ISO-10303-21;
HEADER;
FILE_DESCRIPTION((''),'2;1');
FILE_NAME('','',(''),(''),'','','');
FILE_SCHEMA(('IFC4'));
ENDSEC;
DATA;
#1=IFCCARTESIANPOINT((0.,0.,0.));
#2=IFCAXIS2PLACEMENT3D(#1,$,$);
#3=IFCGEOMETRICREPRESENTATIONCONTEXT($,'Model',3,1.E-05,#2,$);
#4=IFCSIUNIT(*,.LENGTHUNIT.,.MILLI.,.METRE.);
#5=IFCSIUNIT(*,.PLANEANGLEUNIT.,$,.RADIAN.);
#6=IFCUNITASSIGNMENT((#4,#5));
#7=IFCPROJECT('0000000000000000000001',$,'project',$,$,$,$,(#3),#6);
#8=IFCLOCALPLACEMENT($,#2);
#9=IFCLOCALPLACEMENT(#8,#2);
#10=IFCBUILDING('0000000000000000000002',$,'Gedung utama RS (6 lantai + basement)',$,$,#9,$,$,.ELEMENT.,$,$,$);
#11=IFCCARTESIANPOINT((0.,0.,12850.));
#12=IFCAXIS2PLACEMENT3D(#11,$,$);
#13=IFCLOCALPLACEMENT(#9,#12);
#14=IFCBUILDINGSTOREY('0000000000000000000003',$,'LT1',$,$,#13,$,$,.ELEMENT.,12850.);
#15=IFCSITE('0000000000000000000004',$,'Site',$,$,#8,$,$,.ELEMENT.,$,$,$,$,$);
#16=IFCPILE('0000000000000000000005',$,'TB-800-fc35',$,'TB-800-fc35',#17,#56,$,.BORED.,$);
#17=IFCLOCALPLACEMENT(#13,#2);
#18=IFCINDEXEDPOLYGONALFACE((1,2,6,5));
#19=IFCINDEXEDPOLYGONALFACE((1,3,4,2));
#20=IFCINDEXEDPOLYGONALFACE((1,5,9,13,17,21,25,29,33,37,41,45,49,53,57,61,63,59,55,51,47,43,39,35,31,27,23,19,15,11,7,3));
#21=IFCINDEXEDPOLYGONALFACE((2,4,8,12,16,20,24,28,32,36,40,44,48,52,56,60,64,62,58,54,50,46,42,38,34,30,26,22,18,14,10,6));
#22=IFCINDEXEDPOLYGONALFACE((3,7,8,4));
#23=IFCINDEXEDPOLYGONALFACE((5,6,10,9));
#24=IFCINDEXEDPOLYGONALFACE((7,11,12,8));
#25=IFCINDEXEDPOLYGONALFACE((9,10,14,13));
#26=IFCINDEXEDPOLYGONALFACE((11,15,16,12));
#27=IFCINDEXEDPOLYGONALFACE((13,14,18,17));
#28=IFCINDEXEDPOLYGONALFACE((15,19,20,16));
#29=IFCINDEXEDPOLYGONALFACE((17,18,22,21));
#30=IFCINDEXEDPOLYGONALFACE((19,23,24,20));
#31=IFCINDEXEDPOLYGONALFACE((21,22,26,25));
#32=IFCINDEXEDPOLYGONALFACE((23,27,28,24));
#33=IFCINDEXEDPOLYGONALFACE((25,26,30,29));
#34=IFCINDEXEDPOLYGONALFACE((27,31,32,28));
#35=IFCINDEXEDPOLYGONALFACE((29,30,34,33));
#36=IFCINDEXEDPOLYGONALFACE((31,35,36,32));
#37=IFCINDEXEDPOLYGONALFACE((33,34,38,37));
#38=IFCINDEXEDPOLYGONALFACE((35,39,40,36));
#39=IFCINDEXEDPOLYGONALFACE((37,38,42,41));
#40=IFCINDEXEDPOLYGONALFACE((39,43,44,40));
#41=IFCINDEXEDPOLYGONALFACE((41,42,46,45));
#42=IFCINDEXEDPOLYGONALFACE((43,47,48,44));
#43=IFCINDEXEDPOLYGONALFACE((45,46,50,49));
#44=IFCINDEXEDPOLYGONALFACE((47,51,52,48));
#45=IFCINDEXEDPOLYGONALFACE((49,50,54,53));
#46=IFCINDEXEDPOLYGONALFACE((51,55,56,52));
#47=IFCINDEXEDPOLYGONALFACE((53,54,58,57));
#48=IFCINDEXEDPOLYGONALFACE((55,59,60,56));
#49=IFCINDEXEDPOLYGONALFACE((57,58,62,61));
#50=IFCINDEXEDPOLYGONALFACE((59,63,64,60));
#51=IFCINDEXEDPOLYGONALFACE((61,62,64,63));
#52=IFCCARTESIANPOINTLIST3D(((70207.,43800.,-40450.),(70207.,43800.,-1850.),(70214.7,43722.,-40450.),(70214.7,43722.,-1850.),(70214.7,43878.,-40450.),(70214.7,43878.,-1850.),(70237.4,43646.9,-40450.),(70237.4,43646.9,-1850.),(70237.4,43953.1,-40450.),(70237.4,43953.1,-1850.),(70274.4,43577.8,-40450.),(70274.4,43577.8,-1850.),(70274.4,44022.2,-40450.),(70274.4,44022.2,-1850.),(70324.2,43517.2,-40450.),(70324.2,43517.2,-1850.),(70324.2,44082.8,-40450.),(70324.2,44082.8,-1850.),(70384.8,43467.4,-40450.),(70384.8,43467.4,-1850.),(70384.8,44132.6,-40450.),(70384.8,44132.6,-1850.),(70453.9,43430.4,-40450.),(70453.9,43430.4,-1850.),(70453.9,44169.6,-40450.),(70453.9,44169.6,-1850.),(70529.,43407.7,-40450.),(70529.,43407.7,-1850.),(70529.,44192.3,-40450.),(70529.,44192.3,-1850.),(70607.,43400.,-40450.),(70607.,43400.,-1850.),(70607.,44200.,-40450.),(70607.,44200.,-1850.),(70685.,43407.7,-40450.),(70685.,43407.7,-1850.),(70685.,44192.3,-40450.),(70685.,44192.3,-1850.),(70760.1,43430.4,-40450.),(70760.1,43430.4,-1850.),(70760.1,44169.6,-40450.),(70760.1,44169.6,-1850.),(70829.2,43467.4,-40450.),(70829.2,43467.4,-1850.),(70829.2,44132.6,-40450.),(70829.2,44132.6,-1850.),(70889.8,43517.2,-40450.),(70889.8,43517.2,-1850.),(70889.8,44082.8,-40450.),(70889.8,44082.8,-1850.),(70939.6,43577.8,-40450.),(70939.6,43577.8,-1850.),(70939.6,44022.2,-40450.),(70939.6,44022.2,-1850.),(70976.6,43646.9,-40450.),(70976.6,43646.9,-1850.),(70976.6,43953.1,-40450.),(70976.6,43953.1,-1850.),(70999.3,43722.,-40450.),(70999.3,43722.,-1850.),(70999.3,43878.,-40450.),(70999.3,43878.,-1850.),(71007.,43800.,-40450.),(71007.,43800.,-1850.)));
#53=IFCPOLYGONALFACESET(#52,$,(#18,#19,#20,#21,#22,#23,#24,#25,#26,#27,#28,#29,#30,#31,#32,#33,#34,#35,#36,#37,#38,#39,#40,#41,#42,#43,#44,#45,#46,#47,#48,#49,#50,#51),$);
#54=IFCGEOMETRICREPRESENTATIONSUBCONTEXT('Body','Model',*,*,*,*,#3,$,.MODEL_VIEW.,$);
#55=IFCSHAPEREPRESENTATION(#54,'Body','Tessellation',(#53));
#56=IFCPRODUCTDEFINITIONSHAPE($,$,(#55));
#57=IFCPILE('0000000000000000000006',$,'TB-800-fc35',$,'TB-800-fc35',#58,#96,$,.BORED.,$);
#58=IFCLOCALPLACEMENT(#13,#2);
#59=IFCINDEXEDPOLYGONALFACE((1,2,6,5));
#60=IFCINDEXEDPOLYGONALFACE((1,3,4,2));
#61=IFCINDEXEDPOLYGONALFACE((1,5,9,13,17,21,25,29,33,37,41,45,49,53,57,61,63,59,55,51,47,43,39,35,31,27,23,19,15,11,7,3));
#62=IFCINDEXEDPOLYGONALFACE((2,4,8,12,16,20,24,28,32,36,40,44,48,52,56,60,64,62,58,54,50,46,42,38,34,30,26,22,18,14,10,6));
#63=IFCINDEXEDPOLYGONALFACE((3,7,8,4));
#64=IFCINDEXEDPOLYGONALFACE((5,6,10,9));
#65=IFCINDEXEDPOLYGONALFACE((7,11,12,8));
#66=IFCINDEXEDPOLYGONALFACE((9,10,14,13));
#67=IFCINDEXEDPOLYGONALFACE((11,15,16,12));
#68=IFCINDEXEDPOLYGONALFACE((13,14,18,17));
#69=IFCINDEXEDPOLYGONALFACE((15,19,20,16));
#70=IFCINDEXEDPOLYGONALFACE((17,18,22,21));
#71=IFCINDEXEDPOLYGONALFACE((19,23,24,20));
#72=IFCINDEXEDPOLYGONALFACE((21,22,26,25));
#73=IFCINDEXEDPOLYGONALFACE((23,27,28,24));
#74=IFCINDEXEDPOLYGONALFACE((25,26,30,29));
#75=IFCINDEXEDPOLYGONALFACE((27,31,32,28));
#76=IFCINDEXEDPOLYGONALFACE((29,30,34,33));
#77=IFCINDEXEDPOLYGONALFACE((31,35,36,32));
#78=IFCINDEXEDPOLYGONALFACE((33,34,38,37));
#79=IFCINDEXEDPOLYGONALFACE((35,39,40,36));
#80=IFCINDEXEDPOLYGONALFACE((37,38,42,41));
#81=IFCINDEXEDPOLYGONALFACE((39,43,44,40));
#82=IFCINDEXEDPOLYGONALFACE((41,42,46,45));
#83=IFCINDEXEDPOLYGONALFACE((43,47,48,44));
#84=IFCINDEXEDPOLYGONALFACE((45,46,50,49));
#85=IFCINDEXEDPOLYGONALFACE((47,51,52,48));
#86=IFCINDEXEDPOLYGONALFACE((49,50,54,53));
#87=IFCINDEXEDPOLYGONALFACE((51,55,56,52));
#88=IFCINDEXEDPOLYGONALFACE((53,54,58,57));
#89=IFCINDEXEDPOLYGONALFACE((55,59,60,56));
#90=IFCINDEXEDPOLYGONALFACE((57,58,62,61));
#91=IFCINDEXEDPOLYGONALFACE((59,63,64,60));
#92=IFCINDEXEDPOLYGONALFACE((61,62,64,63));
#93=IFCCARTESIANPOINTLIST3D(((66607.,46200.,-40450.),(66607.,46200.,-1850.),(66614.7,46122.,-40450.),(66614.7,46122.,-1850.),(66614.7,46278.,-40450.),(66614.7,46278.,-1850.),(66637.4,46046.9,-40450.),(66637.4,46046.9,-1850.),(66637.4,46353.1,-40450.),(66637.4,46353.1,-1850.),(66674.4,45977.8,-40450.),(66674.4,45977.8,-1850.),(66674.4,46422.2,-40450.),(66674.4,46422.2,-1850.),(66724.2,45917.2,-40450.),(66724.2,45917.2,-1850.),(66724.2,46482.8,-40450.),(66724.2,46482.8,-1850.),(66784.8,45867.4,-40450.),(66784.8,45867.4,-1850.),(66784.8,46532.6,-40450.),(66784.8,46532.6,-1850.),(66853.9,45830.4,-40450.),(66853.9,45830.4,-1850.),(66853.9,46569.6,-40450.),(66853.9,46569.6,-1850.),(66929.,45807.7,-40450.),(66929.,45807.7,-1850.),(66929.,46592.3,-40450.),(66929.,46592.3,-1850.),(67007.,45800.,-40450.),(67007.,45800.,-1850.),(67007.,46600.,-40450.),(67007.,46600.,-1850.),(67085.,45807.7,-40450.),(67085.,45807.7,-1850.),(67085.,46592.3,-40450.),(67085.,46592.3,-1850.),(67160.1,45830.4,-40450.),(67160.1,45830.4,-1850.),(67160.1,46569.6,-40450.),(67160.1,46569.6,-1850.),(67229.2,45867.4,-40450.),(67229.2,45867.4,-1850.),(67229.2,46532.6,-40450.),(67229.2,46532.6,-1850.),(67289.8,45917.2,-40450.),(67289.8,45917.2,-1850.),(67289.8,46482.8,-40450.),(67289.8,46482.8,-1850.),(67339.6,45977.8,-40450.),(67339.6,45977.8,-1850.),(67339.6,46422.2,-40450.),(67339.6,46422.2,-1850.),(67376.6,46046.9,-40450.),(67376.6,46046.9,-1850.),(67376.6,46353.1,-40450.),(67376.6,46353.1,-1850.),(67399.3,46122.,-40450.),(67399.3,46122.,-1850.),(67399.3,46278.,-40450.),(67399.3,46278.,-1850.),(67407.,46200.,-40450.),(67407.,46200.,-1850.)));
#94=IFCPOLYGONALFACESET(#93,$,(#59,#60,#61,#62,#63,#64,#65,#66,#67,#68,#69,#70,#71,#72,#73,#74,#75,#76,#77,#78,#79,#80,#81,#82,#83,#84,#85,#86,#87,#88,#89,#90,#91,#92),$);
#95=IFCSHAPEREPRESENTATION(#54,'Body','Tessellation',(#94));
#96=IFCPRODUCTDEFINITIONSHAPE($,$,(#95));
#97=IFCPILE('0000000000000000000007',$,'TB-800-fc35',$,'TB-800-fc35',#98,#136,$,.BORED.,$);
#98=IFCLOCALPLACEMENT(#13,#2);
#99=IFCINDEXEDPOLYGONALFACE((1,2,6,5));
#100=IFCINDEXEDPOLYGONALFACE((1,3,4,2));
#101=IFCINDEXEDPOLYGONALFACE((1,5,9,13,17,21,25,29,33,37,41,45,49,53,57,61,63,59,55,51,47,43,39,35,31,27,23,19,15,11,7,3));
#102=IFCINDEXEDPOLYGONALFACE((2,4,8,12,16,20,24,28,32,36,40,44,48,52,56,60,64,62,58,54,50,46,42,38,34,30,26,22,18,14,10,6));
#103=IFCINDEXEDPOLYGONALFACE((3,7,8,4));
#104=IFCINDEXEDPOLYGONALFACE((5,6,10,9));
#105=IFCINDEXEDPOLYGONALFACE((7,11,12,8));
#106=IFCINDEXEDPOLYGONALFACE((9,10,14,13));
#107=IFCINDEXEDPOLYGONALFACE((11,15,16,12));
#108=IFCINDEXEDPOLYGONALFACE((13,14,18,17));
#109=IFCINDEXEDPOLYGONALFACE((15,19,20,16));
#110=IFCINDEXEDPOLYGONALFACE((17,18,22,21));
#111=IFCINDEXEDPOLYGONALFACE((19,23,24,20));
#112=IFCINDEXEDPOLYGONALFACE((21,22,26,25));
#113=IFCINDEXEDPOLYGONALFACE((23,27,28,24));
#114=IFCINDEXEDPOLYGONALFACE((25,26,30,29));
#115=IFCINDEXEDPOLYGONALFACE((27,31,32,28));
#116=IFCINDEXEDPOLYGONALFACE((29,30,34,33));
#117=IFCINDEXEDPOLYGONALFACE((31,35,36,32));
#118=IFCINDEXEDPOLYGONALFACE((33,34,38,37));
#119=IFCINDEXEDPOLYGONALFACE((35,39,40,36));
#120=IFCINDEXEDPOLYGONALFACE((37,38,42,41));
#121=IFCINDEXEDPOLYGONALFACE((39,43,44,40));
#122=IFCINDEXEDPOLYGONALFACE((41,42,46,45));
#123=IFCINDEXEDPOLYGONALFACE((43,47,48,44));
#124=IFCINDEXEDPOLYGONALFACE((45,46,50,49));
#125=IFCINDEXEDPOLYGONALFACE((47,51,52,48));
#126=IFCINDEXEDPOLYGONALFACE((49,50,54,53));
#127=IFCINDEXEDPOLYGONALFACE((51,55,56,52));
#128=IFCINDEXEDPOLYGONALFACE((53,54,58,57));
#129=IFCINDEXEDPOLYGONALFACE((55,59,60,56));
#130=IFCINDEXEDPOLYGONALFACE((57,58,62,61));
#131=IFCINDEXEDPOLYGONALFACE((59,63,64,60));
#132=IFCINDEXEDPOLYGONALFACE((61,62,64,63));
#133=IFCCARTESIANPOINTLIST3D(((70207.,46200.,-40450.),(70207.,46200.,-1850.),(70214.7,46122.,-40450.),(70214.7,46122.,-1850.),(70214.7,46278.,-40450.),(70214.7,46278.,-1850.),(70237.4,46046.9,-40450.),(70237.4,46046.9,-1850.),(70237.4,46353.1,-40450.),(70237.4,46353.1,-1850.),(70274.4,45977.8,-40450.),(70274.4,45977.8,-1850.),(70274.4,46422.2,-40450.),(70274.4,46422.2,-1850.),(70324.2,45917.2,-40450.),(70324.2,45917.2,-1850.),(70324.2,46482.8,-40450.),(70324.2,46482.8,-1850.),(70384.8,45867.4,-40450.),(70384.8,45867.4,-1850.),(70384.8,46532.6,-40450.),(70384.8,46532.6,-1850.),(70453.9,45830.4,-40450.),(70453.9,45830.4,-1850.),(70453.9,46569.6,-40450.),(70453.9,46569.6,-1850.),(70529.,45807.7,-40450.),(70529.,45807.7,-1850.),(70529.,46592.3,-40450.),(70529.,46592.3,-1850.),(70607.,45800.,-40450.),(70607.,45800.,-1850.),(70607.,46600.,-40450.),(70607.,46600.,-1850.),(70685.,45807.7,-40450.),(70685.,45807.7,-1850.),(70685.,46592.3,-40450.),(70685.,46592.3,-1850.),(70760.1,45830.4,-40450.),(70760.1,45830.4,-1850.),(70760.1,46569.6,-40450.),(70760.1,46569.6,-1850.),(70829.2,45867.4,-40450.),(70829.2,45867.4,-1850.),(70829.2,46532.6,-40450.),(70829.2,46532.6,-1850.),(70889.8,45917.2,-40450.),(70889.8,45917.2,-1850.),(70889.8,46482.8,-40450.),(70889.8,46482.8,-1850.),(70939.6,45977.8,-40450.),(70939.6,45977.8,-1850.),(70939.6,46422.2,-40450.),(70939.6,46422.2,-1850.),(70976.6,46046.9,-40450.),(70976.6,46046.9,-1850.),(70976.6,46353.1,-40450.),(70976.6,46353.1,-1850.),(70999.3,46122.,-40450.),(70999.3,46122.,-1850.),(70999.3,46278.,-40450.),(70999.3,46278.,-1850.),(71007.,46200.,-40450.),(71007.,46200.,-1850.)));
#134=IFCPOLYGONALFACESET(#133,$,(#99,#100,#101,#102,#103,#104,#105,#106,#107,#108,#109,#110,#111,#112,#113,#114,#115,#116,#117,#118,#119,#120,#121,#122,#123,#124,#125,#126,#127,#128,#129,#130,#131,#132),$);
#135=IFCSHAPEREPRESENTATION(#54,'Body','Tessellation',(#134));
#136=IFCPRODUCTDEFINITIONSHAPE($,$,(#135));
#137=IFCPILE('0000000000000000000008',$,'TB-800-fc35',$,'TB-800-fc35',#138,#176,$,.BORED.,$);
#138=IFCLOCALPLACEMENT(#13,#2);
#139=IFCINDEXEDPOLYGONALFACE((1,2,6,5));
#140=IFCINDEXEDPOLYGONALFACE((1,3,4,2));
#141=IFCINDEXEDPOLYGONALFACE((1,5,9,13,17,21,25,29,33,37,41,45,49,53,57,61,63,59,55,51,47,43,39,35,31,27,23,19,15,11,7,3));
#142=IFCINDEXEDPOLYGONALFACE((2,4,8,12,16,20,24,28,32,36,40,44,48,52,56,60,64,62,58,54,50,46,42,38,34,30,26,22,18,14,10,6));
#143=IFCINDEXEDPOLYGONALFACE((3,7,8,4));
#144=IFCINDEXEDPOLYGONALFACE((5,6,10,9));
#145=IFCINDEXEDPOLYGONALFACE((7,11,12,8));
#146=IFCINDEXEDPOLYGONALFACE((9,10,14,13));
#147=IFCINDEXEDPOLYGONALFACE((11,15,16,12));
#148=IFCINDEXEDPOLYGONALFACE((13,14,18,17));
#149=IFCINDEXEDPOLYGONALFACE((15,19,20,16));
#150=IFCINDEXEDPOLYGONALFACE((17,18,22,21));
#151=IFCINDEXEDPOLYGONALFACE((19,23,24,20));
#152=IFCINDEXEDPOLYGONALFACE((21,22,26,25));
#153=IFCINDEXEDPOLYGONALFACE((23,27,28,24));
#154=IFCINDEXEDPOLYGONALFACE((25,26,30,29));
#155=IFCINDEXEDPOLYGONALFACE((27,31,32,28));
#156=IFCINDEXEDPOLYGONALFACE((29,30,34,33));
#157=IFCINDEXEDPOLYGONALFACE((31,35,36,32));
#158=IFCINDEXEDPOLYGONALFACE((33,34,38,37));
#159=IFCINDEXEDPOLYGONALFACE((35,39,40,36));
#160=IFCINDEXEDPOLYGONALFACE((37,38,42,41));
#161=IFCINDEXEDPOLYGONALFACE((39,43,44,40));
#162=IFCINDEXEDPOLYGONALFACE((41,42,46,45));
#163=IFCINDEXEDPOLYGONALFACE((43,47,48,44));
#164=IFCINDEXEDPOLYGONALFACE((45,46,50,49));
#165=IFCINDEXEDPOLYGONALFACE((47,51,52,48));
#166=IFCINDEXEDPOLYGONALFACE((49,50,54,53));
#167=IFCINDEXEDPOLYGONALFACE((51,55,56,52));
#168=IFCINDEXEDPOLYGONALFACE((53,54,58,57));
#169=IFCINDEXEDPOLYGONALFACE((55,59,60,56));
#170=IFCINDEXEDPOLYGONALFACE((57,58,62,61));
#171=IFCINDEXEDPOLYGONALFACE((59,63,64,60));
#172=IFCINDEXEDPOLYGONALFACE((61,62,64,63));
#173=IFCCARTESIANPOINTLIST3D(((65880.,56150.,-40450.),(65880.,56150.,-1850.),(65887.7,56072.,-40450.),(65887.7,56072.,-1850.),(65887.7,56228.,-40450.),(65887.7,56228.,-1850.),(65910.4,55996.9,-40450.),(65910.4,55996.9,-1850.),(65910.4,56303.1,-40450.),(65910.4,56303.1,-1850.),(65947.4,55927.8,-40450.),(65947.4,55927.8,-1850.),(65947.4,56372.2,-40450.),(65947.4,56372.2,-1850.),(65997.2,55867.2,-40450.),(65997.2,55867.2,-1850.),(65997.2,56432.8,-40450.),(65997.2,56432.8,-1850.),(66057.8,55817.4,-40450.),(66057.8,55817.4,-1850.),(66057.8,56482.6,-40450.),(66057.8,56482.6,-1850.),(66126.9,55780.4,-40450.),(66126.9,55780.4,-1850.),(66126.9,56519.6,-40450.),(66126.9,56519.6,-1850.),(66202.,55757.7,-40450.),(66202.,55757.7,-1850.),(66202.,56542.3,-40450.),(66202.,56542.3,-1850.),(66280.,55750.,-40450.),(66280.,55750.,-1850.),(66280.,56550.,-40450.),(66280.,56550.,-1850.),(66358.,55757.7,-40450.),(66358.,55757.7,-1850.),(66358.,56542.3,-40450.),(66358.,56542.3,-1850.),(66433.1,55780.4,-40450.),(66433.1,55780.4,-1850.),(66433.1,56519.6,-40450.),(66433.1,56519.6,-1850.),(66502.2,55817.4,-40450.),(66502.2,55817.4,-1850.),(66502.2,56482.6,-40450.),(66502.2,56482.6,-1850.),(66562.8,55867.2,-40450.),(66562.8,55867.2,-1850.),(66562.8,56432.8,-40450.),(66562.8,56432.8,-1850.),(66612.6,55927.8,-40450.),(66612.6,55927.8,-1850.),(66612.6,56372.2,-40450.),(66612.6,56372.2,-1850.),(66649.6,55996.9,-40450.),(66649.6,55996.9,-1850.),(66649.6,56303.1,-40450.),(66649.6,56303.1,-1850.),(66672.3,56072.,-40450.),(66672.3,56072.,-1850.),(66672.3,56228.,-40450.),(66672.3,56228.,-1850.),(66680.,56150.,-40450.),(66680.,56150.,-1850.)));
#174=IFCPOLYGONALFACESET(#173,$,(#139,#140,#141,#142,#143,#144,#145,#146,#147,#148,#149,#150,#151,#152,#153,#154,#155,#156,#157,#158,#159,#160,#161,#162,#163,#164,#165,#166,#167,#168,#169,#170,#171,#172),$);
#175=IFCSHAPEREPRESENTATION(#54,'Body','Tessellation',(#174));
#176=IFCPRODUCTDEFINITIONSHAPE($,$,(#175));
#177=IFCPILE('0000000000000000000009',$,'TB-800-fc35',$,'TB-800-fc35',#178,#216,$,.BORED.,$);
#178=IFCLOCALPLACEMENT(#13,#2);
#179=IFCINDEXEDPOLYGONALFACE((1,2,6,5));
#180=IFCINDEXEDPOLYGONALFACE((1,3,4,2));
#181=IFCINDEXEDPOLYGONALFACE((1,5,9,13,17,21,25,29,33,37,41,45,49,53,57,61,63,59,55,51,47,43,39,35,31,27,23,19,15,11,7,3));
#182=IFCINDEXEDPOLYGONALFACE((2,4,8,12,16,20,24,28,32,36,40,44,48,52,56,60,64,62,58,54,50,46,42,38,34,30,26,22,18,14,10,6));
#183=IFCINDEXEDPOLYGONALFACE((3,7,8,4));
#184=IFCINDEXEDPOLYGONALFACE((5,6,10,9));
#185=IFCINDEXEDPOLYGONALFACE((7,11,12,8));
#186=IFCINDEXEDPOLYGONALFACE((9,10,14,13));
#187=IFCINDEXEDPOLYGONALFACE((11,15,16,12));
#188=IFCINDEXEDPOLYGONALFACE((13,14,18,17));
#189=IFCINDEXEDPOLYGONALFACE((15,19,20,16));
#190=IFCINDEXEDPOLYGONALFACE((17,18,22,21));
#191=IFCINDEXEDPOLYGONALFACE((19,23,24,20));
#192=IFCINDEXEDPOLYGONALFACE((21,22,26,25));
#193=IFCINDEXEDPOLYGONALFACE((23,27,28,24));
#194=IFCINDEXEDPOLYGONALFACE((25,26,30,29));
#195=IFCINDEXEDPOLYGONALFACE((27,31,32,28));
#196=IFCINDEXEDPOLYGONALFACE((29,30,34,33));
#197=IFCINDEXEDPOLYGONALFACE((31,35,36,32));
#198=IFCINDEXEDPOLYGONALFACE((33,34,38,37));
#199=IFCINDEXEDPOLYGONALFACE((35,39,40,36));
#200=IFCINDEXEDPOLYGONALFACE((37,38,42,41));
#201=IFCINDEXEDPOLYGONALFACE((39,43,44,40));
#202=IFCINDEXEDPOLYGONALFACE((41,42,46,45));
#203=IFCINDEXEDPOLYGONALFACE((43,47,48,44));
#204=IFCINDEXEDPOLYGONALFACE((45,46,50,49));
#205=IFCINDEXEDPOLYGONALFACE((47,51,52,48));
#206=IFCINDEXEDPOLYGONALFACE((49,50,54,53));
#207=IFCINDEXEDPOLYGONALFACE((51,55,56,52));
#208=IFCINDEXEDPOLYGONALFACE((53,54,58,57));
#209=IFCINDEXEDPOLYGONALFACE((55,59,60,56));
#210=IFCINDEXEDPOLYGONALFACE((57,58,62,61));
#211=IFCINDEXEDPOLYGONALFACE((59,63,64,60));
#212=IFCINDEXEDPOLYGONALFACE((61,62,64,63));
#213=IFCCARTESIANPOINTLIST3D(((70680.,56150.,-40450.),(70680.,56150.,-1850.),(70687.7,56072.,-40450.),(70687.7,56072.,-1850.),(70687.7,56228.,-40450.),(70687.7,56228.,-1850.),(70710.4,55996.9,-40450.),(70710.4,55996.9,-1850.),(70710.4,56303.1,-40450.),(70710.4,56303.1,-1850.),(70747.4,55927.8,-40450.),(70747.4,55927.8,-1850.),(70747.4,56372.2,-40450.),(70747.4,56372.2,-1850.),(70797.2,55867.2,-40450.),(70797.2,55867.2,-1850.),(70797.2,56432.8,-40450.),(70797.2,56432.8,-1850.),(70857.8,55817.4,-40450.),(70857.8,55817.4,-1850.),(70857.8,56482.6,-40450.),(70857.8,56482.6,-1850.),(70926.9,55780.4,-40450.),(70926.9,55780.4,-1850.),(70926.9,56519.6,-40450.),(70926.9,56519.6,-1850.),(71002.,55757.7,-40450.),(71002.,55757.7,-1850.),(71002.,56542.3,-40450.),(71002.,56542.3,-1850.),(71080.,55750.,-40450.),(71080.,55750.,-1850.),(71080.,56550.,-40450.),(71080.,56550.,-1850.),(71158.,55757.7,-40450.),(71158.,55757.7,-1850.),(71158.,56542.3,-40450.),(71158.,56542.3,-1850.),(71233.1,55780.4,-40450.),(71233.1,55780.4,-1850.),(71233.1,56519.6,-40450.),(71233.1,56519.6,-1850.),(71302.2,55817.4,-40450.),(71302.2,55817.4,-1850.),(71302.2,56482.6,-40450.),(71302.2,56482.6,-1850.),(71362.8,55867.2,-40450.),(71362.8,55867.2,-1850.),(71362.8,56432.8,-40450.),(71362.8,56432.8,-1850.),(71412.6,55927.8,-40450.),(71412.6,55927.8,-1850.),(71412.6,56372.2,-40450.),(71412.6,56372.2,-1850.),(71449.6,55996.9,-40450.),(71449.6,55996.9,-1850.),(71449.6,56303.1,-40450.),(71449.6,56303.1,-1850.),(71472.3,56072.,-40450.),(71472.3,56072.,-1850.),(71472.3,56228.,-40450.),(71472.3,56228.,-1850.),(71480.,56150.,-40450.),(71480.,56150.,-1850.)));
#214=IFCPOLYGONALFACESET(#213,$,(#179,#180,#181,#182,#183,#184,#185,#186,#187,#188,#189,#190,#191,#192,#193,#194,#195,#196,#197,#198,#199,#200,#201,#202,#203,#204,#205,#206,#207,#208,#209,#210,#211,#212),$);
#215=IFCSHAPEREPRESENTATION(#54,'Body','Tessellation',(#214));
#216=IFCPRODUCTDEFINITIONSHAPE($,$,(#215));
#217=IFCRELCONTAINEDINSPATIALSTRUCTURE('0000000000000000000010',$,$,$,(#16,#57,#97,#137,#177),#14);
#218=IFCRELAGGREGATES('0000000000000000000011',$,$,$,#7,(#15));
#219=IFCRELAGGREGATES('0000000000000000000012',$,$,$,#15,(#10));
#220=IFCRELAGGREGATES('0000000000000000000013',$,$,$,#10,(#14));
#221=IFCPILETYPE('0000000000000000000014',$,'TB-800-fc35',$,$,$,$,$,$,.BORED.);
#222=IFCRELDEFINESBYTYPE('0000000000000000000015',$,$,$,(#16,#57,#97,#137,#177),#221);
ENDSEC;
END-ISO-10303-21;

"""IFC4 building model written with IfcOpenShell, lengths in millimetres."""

from ifc_helpers import new_model, si_unit, frame, origin, origin_2d, place, context, subcontext, project, spatial, circle, extrude, material_profile, profile_set, profile_usage, type_object, element, save


model = new_model("IFC4")

# Units and contexts
model_context = context("Model", 3, precision=1e-05, world=origin())
body_context = subcontext(model_context, "Body", "Model", "MODEL_VIEW")
ifc_project = project(units=[si_unit("LENGTHUNIT", "METRE", prefix="MILLI"), si_unit("PLANEANGLEUNIT", "RADIAN")], contexts=[model_context])

# Site, building, storey
site_placement = place(None, origin())
site = spatial("IfcSite", under=ifc_project, at=site_placement, Name="Site", CompositionType="ELEMENT")
building_placement = place(site_placement, origin())
building = spatial("IfcBuilding", under=site, at=building_placement, Name="Gedung utama RS (6 lantai + basement)", CompositionType="ELEMENT")
storey_placement = place(building_placement, frame((0.0, 0.0, 12850.0)))
storey = spatial("IfcBuildingStorey", under=building, at=storey_placement, Name="LT1", CompositionType="ELEMENT", Elevation=12850.0)

# Piles
ifc_material_profile = material_profile(None, circle(Radius=400.0, at=origin_2d()), Name="TB-800-fc35")
ifc_profile_set = profile_set([ifc_material_profile], Name="TB-800-fc35")
ifc_profile_usage = profile_usage(ifc_profile_set, cardinal=5)
pile_type = type_object("IfcPileType", Name="TB-800-fc35", PredefinedType="BORED", material=ifc_profile_set)
for number, where, z_axis, x_axis, name in (
    (1, (70607.0, 43800.0, -40450.0), (0.0, 0.0, 1.0), (1.0, 0.0, 0.0), "TB-800-fc35"),
    (2, (67007.0, 46200.0, -40450.0), (0.0, 0.0, 1.0), (1.0, 0.0, 0.0), "TB-800-fc35"),
    (3, (70607.0, 46200.0, -40450.0), (0.0, 0.0, 1.0), (1.0, 0.0, 0.0), "TB-800-fc35"),
    (4, (66280.0, 56150.0, -40450.0), (0.0, 0.0, 1.0), (1.0, 0.0, 0.0), "TB-800-fc35"),
    (5, (71080.0, 56150.0, -40450.0), (0.0, 0.0, 1.0), (1.0, 0.0, 0.0), "TB-800-fc35"),
):
    element("IfcPile", number, at=place(storey_placement, frame(where, z_axis=z_axis, x_axis=x_axis)), inside=storey, type_object=pile_type, material=ifc_profile_usage, Name=name, ObjectType="TB-800-fc35", PredefinedType="BORED", context=body_context, shape_type="SweptSolid", body=[
        extrude(circle(Radius=400.0, at=origin_2d()), origin(), (0.0, 0.0, 1.0), 38600.0),
    ])

save(model, "model.ifc")
